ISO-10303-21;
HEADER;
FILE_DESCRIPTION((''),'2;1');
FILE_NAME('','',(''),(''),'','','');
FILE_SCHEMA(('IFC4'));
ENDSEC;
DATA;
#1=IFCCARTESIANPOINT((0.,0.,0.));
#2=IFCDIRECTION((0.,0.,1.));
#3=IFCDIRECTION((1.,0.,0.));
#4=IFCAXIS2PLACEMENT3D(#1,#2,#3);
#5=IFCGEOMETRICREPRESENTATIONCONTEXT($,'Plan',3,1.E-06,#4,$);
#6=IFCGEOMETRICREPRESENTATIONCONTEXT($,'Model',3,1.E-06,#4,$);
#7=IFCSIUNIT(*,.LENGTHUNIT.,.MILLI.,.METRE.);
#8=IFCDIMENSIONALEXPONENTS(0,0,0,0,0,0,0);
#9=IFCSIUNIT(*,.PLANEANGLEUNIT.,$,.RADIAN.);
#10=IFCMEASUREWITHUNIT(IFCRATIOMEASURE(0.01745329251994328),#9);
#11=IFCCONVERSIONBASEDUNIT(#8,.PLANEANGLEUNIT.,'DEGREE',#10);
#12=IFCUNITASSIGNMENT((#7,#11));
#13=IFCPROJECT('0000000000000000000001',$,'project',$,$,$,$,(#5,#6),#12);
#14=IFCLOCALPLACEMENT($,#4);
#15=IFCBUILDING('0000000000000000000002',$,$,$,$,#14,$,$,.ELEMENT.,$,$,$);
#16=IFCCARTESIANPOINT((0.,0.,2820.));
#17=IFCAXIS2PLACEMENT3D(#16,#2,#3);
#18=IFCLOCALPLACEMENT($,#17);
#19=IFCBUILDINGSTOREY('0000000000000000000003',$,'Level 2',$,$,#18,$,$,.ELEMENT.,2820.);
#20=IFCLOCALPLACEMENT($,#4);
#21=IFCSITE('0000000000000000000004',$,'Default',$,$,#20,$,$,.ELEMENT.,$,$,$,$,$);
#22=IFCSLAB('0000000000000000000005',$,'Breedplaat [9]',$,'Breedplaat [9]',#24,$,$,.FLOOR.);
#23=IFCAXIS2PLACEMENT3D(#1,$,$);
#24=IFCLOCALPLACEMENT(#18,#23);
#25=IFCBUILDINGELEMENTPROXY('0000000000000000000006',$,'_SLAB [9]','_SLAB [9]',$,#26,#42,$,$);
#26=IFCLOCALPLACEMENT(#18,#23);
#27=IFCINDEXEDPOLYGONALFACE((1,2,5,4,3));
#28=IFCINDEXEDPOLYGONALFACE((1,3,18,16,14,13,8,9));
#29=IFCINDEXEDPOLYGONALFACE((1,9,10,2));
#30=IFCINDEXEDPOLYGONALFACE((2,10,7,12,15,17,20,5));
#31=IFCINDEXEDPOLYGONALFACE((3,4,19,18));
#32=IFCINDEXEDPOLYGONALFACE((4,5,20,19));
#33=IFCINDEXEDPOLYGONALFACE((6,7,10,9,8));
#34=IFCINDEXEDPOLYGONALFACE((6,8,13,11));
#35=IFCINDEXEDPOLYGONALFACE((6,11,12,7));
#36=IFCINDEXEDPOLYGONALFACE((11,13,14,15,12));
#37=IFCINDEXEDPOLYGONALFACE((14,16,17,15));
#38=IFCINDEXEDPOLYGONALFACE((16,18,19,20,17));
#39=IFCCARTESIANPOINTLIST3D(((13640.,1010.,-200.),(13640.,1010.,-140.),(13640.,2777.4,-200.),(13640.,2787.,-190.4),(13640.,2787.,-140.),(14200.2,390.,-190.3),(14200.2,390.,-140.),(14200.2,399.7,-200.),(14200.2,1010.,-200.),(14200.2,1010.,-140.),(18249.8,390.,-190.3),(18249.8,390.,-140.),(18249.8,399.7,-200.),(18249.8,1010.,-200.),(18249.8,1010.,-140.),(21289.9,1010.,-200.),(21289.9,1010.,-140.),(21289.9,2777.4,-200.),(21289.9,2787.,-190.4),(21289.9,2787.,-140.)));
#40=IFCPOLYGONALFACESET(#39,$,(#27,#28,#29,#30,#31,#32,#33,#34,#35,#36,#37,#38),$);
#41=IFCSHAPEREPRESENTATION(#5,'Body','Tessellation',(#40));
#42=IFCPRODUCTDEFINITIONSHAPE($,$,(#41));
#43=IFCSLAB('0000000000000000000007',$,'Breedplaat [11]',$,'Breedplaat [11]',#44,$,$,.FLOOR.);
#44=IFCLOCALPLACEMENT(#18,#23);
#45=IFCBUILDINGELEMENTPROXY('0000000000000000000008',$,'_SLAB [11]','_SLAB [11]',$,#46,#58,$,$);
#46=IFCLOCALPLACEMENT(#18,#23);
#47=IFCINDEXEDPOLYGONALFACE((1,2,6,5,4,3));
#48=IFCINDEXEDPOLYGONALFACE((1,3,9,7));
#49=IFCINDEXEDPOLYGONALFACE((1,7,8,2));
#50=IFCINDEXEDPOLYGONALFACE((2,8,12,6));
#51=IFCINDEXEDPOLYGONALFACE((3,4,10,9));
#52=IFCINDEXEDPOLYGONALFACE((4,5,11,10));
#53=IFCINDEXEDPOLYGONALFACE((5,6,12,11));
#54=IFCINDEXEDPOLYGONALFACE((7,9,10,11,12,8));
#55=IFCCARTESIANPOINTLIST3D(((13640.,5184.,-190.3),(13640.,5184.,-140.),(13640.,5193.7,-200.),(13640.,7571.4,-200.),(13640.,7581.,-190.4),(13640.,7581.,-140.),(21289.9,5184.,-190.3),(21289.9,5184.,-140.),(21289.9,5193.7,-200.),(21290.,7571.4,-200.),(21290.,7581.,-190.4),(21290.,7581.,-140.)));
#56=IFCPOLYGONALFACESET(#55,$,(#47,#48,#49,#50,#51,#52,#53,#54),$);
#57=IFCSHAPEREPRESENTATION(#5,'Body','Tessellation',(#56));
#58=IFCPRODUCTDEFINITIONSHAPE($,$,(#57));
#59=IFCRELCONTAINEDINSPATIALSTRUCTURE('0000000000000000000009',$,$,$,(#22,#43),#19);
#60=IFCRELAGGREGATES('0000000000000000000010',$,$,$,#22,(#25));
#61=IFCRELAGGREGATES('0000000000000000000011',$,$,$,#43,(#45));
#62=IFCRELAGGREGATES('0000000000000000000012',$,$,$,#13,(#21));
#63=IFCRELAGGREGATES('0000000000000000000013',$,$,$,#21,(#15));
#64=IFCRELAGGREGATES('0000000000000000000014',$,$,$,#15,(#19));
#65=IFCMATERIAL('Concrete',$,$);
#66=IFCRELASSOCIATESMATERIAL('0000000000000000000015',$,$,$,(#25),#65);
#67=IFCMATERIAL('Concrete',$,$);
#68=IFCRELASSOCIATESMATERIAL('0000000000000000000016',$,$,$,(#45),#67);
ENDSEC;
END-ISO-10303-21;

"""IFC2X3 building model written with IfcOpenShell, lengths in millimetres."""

from ifc_helpers import new_model, entity, si_unit, converted_unit, frame, origin_with_axes, place, context, project, spatial, polyline, outline, extrude, material, element, aggregate, save


model = new_model("IFC2X3")

# Units and contexts
plan_context = context("Plan", 3, precision=1e-06, world=origin_with_axes())
model_context = context("Model", 3, precision=1e-06, world=origin_with_axes())
ifc_project = project(units=[si_unit("LENGTHUNIT", "METRE", prefix="MILLI"), converted_unit("PLANEANGLEUNIT", "DEGREE", entity("IfcRatioMeasure", 0.01745329251994328), si_unit("PLANEANGLEUNIT", "RADIAN"), dimensions=[0, 0, 0, 0, 0, 0, 0])], contexts=[plan_context, model_context])

# Site, building, storey
site_placement = place(None, origin_with_axes())
site = spatial("IfcSite", under=ifc_project, at=site_placement, Name="Default", CompositionType="ELEMENT")
building_placement = place(None, origin_with_axes())
building = spatial("IfcBuilding", under=site, at=building_placement, CompositionType="ELEMENT")
storey_placement = place(None, frame((0.0, 0.0, 2820.0), z_axis=(0.0, 0.0, 1.0), x_axis=(1.0, 0.0, 0.0)))
storey = spatial("IfcBuildingStorey", under=building, at=storey_placement, Name="Level 2", CompositionType="ELEMENT", Elevation=2820.0)

# Slabs, building element proxies, openings
slab_1_placement = place(None, frame((13640.0, 390.0, 2620.0), z_axis=(0.0, 0.0, 1.0), x_axis=(1.0, 0.0, 0.0)))
slab_1 = element("IfcSlab", 1, at=slab_1_placement, inside=storey, Name="Breedplaat [9]", ObjectType="Breedplaat [9]", PredefinedType="FLOOR")
ifc_material_1 = material(Name="Concrete")
proxy_1_placement = place(slab_1_placement, origin_with_axes())
proxy_1 = element("IfcBuildingElementProxy", 2, at=proxy_1_placement, material=ifc_material_1, Name="_SLAB [9]", Description="_SLAB [9]", context=plan_context, shape_type="SweptSolid", body=[
    extrude(outline(polyline([(4609.8, 0.0), (4609.8, 620.0), (7649.9, 620.0), (7649.9, 2397.0), (0.0, 2397.0), (0.0, 620.0), (560.2, 620.0), (560.2, 0.0), (4609.8, 0.0)])), origin_with_axes(), (0.0, 0.0, 1.0), 60.0),
])
opening_1_placement = place(None, frame((13640.0, 390.0, 2620.0), z_axis=(0.0, 0.0, 1.0), x_axis=(1.0, 0.0, 0.0)))
element("IfcOpeningElement", 3, at=opening_1_placement, cuts=proxy_1, ObjectType="Opening", context=plan_context, shape_type="SweptSolid", body=[
    extrude(outline(polyline([(-0.1, -0.1), (-0.1, 10.0), (10.0, -0.1), (-0.1, -0.1)])), frame((559.0, -0.1, -0.1), z_axis=(1.0, 0.0, 0.0), x_axis=(0.0, 1.0, 0.0)), (0.0, 0.0, 1.0), 4051.8),
])
opening_2_placement = place(None, frame((13640.0, 390.0, 2620.0), z_axis=(0.0, 0.0, 1.0), x_axis=(1.0, 0.0, 0.0)))
element("IfcOpeningElement", 4, at=opening_2_placement, cuts=proxy_1, ObjectType="Opening", context=plan_context, shape_type="SweptSolid", body=[
    extrude(outline(polyline([(-0.1, -0.1), (-0.1, 10.0), (10.0, -0.1), (-0.1, -0.1)])), frame((7651.1, 2397.2, -0.1), z_axis=(-1.0, 0.0, 0.0), x_axis=(0.0, -1.0, 0.0)), (0.0, 0.0, 1.0), 7652.1),
])
aggregate(slab_1, [proxy_1])
slab_2_placement = place(None, frame((13640.0, 5184.0, 2620.0), z_axis=(0.0, 0.0, 1.0), x_axis=(1.0, 0.0, 0.0)))
slab_2 = element("IfcSlab", 5, at=slab_2_placement, inside=storey, Name="Breedplaat [11]", ObjectType="Breedplaat [11]", PredefinedType="FLOOR")
ifc_material_2 = material(Name="Concrete")
proxy_2_placement = place(slab_2_placement, origin_with_axes())
proxy_2 = element("IfcBuildingElementProxy", 6, at=proxy_2_placement, material=ifc_material_2, Name="_SLAB [11]", Description="_SLAB [11]", context=plan_context, shape_type="SweptSolid", body=[
    extrude(outline(polyline([(0.0, 0.0), (7649.9, 0.0), (7650.0, 2397.0), (0.0, 2397.0), (0.0, 0.0)])), origin_with_axes(), (0.0, 0.0, 1.0), 60.0),
])
opening_3_placement = place(None, frame((13640.0, 5184.0, 2620.0), z_axis=(0.0, 0.0, 1.0), x_axis=(1.0, 0.0, 0.0)))
element("IfcOpeningElement", 7, at=opening_3_placement, cuts=proxy_2, ObjectType="Opening", context=plan_context, shape_type="SweptSolid", body=[
    extrude(outline(polyline([(-0.1, -0.1), (-0.1, 10.0), (10.0, -0.1), (-0.1, -0.1)])), frame((-1.2, -0.1, -0.1), z_axis=(1.0, 0.0, 0.0), x_axis=(0.0, 1.0, 0.0)), (0.0, 0.0, 1.0), 7652.1),
])
opening_4_placement = place(None, frame((13640.0, 5184.0, 2620.0), z_axis=(0.0, 0.0, 1.0), x_axis=(1.0, 0.0, 0.0)))
element("IfcOpeningElement", 8, at=opening_4_placement, cuts=proxy_2, ObjectType="Opening", context=plan_context, shape_type="SweptSolid", body=[
    extrude(outline(polyline([(-0.1, -0.1), (-0.1, 10.0), (10.0, -0.1), (-0.1, -0.1)])), frame((7651.2, 2397.2, -0.1), z_axis=(-1.0, 0.0, 0.0), x_axis=(0.0, -1.0, 0.0)), (0.0, 0.0, 1.0), 7652.2),
])
aggregate(slab_2, [proxy_2])

save(model, "model.ifc")
